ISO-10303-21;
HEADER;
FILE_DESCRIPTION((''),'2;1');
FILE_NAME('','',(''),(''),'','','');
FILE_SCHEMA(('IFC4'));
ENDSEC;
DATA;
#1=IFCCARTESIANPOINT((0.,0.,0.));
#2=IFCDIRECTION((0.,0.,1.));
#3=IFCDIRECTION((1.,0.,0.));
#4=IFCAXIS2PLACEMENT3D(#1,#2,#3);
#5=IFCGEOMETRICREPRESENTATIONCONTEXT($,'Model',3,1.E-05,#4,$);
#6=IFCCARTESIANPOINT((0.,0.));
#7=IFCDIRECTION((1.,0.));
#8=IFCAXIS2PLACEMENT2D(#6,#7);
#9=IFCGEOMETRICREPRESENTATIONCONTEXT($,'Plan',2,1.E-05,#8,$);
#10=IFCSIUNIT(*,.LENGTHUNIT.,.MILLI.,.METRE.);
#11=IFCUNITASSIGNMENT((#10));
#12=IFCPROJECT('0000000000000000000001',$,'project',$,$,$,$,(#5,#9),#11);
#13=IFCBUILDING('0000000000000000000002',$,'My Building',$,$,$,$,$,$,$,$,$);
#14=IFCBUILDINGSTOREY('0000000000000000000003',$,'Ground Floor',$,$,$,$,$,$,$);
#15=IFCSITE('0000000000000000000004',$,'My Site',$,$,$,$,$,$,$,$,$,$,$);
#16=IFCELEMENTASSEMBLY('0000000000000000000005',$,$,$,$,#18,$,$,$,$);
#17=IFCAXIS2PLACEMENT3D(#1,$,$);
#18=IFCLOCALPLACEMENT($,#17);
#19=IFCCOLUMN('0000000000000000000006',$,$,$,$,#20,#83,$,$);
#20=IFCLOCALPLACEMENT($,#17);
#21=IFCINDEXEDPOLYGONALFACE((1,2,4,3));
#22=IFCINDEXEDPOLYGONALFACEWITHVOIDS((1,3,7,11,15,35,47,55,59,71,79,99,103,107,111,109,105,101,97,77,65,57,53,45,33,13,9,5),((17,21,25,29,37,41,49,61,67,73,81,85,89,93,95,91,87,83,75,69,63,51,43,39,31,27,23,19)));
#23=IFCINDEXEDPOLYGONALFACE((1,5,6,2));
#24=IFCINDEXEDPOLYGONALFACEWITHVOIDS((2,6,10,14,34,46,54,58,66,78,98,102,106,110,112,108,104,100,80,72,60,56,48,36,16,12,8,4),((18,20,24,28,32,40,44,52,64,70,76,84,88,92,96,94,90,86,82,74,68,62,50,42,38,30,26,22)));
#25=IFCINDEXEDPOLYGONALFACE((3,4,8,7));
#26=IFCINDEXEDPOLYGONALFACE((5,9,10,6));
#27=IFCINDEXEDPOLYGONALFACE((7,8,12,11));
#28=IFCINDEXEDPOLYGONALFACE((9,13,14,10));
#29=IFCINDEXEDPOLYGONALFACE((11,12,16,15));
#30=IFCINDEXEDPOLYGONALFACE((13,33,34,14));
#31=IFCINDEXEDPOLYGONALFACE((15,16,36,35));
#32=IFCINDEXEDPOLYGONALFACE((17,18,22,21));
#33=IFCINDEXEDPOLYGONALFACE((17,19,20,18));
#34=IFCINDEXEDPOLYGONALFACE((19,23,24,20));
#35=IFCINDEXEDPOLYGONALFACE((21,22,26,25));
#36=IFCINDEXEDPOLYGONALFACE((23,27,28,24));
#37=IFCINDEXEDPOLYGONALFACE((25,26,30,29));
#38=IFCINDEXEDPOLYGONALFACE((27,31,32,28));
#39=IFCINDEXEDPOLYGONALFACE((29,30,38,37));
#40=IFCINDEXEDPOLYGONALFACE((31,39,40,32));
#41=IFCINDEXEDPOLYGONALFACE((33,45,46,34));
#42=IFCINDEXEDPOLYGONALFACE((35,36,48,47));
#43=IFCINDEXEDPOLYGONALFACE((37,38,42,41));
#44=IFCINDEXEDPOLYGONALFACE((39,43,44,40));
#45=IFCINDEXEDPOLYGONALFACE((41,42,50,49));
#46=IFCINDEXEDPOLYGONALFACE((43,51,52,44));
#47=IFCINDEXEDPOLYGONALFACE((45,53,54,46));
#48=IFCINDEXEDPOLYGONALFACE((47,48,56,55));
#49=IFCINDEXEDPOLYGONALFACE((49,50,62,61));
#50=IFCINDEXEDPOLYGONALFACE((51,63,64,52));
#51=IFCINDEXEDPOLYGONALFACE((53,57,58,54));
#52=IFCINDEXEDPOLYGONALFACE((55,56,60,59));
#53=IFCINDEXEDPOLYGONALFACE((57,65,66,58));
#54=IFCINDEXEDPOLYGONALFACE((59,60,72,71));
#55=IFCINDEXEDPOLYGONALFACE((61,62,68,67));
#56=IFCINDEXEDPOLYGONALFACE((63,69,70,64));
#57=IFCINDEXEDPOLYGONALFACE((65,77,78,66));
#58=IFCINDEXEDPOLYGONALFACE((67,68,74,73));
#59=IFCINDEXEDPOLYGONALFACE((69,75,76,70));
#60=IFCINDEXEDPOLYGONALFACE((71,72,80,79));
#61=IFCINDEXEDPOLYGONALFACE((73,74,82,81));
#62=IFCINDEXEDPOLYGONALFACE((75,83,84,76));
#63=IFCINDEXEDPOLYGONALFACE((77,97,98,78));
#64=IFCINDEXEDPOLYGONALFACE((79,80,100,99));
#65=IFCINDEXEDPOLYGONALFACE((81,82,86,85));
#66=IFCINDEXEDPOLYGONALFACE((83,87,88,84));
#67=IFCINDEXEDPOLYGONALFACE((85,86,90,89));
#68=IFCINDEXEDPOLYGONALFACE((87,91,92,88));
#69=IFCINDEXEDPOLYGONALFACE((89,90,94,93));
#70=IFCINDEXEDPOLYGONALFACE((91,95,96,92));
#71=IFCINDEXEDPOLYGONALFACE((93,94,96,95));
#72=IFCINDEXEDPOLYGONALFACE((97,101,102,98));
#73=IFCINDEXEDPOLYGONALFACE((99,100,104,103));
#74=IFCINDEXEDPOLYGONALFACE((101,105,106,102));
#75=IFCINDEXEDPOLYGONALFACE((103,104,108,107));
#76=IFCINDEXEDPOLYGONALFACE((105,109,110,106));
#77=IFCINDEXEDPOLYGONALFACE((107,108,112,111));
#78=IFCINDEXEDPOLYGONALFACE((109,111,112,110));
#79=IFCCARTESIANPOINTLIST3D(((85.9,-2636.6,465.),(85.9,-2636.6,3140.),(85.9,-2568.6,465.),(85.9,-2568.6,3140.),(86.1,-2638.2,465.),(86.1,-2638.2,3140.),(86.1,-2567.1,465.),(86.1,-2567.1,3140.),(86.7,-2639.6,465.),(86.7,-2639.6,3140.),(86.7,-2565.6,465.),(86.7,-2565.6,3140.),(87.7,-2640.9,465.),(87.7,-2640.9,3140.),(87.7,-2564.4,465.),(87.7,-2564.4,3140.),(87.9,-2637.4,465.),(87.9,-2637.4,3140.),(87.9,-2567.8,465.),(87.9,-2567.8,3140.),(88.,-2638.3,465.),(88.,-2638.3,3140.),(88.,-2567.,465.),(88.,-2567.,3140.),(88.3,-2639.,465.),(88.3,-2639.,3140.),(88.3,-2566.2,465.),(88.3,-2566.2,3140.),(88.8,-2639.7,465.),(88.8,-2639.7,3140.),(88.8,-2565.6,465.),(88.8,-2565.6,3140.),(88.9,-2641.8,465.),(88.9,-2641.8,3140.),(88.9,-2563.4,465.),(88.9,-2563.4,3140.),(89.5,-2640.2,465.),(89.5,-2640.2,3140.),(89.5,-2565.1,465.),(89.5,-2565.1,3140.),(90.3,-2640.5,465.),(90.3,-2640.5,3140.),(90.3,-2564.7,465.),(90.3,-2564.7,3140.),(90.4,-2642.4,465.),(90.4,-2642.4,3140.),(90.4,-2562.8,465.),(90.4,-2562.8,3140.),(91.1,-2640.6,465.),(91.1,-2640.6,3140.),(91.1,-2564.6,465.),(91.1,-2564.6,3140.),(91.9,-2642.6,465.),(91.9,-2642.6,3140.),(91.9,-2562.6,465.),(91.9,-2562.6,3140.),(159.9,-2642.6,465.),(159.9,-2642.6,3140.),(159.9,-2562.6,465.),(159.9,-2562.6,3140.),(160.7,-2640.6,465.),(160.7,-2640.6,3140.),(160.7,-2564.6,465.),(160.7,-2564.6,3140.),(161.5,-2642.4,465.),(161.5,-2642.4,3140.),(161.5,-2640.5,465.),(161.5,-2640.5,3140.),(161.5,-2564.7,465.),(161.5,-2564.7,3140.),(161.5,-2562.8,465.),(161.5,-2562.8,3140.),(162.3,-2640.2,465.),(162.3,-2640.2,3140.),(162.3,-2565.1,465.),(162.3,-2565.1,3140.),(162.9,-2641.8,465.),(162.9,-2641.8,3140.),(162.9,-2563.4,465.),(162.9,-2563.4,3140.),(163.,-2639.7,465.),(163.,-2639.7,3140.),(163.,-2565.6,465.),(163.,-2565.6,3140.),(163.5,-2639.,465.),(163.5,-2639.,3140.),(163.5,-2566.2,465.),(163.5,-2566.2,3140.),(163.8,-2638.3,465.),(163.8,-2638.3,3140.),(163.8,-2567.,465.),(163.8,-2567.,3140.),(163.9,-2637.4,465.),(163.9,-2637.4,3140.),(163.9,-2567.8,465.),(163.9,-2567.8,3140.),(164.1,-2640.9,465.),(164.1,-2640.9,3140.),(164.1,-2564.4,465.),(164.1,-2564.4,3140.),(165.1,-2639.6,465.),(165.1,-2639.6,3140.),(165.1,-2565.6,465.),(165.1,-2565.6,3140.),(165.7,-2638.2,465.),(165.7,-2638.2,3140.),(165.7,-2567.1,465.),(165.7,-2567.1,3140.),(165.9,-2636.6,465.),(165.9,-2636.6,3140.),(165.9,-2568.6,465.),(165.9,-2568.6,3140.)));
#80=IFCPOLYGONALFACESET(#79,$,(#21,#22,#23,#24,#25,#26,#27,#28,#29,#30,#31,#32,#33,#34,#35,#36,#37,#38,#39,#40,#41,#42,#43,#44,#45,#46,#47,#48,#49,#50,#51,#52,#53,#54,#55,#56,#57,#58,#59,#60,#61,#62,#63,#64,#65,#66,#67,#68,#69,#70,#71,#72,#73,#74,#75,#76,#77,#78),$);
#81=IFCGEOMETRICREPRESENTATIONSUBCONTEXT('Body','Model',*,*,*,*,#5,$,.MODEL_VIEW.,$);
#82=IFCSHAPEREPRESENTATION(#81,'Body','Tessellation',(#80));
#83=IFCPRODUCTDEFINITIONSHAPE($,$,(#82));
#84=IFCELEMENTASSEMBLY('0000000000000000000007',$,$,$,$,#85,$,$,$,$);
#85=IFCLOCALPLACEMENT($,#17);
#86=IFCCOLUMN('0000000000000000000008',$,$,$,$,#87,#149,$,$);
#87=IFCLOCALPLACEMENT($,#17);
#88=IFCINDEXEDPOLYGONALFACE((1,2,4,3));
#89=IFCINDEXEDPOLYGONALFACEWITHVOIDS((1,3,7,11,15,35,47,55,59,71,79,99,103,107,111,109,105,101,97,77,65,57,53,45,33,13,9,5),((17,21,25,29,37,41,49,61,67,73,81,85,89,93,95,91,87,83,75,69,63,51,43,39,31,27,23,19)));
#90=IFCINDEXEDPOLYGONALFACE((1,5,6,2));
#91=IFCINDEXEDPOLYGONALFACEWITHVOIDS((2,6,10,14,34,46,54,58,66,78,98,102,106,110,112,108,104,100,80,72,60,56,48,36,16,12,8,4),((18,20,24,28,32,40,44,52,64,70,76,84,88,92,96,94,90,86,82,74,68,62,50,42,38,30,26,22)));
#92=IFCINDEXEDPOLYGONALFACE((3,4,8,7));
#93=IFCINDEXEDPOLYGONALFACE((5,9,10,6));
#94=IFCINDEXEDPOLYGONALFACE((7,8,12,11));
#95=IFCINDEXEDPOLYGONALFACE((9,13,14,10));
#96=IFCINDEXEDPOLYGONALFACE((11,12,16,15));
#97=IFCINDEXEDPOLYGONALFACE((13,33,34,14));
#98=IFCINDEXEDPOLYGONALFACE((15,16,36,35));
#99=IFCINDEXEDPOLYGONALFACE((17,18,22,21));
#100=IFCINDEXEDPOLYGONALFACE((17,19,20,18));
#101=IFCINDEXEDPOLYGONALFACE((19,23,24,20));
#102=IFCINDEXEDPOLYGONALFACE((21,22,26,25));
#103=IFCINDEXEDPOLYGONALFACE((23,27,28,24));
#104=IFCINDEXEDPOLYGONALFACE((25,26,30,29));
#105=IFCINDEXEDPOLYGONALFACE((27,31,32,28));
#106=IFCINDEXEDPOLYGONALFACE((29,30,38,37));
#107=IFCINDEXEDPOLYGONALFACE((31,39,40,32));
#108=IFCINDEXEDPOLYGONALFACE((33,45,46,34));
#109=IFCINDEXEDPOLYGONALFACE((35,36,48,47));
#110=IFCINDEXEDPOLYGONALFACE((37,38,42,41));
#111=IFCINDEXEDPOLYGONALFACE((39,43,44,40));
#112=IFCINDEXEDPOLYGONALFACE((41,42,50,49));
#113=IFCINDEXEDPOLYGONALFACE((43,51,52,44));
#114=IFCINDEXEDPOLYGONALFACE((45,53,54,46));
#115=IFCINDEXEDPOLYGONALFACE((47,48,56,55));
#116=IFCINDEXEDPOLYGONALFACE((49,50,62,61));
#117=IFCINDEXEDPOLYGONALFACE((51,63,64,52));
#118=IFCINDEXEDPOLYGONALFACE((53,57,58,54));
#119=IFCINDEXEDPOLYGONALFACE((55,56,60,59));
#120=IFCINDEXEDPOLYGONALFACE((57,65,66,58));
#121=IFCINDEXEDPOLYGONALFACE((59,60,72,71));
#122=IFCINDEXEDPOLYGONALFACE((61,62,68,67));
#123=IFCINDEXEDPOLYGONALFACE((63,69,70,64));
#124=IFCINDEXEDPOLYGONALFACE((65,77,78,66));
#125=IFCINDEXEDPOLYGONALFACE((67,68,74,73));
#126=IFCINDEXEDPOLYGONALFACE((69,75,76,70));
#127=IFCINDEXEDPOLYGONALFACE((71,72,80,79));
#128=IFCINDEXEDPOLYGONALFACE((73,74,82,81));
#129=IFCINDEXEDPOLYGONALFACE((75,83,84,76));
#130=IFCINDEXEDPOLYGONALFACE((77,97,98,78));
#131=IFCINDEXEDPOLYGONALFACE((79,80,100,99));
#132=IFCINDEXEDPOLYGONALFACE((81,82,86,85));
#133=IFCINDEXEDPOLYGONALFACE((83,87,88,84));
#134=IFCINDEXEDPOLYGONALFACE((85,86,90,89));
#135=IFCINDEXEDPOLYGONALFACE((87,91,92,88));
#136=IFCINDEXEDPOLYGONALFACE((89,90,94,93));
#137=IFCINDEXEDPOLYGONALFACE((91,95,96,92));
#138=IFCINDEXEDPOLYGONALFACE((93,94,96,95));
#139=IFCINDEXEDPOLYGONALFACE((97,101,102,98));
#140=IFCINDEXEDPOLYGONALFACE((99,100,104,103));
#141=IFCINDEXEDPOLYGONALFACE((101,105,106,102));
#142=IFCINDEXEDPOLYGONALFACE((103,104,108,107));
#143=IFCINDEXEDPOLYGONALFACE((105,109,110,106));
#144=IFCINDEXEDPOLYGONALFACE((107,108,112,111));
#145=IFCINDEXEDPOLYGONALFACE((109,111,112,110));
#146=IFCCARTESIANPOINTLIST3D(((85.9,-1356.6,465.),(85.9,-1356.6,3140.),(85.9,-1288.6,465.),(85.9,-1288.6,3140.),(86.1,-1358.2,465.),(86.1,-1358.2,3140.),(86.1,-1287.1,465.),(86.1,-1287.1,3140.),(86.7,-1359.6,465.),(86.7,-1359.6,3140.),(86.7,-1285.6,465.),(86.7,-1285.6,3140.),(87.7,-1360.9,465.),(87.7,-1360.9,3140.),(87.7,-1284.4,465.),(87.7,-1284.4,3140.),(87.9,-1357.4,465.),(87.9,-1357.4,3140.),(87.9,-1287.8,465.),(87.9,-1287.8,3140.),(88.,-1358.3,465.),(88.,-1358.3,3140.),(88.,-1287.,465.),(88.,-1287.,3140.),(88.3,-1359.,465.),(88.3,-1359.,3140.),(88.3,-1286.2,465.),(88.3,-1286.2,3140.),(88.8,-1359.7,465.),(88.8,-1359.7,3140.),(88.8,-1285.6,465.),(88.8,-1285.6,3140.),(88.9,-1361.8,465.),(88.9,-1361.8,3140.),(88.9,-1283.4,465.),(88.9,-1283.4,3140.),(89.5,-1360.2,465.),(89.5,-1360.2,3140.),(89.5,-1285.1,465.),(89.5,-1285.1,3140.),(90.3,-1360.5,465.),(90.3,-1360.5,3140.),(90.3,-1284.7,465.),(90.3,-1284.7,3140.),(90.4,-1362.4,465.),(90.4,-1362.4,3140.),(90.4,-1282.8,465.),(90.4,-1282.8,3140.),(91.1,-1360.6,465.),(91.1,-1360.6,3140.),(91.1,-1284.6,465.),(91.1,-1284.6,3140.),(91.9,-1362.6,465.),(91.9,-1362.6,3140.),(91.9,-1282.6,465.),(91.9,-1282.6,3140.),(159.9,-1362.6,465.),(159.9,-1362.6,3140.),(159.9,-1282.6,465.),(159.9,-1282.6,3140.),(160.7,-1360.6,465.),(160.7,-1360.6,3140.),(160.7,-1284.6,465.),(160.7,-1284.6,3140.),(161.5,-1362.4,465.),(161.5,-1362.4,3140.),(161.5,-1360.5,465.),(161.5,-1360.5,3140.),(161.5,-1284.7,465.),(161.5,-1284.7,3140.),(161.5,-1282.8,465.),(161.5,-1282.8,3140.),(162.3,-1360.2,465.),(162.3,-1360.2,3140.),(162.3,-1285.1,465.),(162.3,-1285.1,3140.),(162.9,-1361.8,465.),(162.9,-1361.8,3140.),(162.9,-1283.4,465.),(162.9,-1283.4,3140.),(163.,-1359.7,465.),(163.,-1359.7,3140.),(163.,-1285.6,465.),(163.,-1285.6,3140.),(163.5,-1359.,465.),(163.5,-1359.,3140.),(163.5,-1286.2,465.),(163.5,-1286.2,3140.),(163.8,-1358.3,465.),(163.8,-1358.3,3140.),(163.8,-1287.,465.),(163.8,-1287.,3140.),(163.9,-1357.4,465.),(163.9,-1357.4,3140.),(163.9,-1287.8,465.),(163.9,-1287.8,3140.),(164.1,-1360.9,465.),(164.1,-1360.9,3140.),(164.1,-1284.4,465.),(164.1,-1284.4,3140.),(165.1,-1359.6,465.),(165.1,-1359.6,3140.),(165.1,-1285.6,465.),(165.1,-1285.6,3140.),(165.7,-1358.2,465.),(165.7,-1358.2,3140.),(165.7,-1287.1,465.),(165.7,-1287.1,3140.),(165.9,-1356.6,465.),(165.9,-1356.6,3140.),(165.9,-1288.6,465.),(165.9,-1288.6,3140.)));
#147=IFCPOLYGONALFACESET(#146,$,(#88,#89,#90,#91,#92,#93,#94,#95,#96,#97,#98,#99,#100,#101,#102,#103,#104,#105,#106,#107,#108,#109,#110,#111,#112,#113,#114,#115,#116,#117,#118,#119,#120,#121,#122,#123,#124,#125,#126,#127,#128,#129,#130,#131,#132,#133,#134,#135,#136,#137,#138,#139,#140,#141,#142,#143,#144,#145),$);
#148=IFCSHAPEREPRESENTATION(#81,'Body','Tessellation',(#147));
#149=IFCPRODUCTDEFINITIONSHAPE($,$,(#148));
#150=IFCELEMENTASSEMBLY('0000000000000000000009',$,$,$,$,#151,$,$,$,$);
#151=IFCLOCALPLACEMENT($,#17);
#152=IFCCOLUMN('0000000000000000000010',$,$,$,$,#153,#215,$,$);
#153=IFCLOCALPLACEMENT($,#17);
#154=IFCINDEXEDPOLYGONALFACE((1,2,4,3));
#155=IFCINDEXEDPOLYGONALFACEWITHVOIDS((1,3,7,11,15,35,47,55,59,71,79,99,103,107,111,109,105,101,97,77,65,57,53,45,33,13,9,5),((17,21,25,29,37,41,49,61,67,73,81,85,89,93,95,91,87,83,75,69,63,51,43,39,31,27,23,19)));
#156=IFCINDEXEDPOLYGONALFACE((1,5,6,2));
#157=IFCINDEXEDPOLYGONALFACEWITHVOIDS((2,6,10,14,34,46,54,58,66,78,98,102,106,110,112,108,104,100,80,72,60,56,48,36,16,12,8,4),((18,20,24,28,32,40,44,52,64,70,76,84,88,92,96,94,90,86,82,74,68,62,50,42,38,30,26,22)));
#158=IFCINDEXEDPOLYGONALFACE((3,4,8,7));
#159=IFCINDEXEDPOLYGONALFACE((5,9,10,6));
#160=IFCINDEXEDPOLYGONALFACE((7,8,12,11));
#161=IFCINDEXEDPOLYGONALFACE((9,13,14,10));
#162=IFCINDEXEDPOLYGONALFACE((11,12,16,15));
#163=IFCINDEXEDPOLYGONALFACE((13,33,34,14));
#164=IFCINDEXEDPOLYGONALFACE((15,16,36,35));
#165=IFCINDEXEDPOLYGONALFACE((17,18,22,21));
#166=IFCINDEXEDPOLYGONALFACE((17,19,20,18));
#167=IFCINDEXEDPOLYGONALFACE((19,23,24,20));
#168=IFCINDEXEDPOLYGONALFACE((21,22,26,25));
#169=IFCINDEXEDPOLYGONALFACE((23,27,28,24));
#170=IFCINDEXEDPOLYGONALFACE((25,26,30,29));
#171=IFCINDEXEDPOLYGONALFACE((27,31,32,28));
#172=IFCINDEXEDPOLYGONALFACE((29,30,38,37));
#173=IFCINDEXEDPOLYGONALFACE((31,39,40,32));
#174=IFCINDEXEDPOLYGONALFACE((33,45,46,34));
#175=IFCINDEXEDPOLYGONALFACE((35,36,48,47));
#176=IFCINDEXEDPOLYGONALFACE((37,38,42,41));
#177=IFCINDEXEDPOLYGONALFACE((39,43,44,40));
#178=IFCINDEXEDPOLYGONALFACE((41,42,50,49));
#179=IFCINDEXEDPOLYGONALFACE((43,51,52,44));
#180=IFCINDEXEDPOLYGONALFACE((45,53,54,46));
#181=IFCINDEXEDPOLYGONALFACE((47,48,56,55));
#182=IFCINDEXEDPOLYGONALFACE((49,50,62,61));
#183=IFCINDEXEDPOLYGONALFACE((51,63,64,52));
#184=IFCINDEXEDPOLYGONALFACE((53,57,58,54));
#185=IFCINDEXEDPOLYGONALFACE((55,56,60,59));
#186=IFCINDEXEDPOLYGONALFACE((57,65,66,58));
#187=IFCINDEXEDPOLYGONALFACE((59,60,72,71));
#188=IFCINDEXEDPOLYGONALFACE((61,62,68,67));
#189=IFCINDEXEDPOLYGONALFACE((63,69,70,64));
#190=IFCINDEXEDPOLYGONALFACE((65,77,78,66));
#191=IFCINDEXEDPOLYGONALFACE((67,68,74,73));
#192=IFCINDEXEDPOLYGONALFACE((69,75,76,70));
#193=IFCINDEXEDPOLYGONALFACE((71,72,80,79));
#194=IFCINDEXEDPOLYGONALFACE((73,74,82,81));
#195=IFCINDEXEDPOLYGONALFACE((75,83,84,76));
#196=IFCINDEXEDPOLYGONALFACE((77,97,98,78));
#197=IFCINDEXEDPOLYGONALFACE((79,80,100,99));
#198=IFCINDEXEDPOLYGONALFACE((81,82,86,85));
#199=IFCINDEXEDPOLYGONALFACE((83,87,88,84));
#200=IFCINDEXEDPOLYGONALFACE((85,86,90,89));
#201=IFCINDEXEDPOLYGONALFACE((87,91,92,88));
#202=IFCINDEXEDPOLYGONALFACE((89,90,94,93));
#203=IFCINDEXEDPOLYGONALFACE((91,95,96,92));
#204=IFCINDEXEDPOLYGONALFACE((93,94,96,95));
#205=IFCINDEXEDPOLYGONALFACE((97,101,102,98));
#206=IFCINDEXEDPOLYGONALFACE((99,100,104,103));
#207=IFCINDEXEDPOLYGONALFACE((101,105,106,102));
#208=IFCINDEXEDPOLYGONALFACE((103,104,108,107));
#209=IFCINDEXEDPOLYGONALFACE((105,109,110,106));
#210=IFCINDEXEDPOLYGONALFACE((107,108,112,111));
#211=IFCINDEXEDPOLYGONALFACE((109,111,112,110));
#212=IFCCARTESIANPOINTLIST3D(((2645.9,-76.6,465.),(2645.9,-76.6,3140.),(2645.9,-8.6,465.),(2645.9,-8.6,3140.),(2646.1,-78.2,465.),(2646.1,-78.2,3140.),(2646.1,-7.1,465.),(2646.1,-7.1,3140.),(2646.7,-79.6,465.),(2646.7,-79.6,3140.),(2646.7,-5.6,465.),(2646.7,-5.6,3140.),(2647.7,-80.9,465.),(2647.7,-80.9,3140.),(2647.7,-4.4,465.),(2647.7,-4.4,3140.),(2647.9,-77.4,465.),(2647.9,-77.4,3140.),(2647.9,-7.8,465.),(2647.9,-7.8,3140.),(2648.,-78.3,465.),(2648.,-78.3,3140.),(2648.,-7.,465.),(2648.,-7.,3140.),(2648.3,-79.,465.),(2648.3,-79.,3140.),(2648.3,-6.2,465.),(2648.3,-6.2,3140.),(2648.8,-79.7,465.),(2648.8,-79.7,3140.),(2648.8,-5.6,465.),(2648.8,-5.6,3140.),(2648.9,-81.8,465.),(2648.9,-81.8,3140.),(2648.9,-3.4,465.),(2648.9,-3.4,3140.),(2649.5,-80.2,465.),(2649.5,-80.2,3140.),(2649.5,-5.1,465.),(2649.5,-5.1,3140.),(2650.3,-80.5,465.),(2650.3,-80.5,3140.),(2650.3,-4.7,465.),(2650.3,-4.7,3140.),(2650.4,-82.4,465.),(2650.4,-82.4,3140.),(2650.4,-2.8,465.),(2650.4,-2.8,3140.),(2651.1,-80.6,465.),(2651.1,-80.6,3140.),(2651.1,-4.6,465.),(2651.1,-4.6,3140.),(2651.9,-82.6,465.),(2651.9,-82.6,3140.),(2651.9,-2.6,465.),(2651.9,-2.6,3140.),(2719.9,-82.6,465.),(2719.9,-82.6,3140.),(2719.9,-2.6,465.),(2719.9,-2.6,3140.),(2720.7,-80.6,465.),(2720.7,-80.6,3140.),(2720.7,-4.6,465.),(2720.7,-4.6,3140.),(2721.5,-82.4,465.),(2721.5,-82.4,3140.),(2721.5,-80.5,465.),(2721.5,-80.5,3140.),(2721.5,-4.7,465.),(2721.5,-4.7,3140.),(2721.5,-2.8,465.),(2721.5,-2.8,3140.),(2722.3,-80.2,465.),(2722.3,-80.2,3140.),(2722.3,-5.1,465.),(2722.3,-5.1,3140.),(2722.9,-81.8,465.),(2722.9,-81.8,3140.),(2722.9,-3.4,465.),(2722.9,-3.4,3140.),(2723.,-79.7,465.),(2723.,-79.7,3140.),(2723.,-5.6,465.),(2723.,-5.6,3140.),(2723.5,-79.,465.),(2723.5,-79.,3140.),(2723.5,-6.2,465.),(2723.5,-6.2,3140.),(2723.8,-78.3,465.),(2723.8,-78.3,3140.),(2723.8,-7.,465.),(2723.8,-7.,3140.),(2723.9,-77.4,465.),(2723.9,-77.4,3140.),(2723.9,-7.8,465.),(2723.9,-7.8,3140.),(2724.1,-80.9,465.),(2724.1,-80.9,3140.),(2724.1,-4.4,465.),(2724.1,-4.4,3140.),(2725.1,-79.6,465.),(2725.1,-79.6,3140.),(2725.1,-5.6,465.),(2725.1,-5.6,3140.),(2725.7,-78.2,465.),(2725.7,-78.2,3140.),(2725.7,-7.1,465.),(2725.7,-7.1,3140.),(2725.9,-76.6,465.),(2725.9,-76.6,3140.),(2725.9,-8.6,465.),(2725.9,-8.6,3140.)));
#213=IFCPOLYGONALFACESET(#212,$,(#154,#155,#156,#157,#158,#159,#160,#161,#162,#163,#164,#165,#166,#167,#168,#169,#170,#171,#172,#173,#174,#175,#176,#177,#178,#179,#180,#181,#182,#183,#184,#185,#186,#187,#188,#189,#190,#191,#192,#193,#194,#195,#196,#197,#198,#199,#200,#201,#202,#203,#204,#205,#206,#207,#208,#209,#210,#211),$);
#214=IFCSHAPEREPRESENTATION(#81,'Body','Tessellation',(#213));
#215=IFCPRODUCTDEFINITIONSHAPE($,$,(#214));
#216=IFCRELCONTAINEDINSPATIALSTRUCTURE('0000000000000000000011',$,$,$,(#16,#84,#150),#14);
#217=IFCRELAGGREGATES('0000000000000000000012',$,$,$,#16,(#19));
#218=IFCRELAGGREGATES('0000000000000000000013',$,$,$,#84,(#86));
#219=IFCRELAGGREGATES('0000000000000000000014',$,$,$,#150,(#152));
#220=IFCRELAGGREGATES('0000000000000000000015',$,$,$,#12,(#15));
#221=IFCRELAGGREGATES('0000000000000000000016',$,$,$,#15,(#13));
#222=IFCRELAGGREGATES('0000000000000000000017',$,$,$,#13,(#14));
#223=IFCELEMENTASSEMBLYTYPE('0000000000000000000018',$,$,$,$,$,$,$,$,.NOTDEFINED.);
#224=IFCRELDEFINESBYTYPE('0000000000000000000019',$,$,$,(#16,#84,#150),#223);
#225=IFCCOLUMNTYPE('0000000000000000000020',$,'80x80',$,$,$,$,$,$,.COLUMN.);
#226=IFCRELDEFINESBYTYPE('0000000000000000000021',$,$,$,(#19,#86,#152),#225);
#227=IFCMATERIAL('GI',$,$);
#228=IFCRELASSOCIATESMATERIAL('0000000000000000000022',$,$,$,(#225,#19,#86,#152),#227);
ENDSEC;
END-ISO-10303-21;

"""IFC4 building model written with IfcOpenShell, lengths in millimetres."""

from ifc_helpers import new_model, si_unit, frame, origin_with_axes, origin_2d_with_axis, place, context, subcontext, project, spatial, hollow_rectangle, extrude, material, material_profile, profile_set, profile_usage, type_object, element, aggregate, save


model = new_model("IFC4")

# Units and contexts
model_context = context("Model", 3, precision=1e-05, world=origin_with_axes())
plan_context = context("Plan", 2, precision=1e-05, world=origin_2d_with_axis())
body_context = subcontext(model_context, "Body", "Model", "MODEL_VIEW")
ifc_project = project(units=[si_unit("LENGTHUNIT", "METRE", prefix="MILLI")], contexts=[model_context, plan_context])

# Site, building, storey
site = spatial("IfcSite", under=ifc_project, Name="My Site")
building = spatial("IfcBuilding", under=site, Name="My Building")
storey = spatial("IfcBuildingStorey", under=building, Name="Ground Floor")

# Element assemblies, columns
element_assembly_type_1 = type_object("IfcElementAssemblyType", PredefinedType="NOTDEFINED")
ifc_material_1 = material(Name="GI")
ifc_material_profile_1 = material_profile(ifc_material_1, hollow_rectangle(XDim=80.0, YDim=80.0, WallThickness=2.0, InnerFilletRadius=3.2, OuterFilletRadius=6.0))
ifc_profile_set_1 = profile_set([ifc_material_profile_1], Name="80x80 GI Rectangular Hollow")
column_type = type_object("IfcColumnType", Name="80x80", PredefinedType="COLUMN", material=ifc_profile_set_1)
assembly_1_placement = place(None, frame((125.9, -2602.6, 465.0), z_axis=(0.0, 0.0, 1.0), x_axis=(1.0, 0.0, 0.0)))
assembly_1 = element("IfcElementAssembly", 1, at=assembly_1_placement, inside=storey, type_object=element_assembly_type_1)
ifc_profile_usage_1 = profile_usage(ifc_profile_set_1)
column_1_placement = place(assembly_1_placement, origin_with_axes())
column_1 = element("IfcColumn", 2, at=column_1_placement, type_object=column_type, material=ifc_profile_usage_1, context=body_context, shape_type="SweptSolid", body=[
    extrude(hollow_rectangle(XDim=80.0, YDim=80.0, WallThickness=2.0, InnerFilletRadius=3.2, OuterFilletRadius=6.0), origin_with_axes(), (0.0, 0.0, 1.0), 2675.0),
])
aggregate(assembly_1, [column_1])
assembly_2_placement = place(None, frame((125.9, -1322.6, 465.0), z_axis=(0.0, 0.0, 1.0), x_axis=(1.0, 0.0, 0.0)))
assembly_2 = element("IfcElementAssembly", 3, at=assembly_2_placement, inside=storey, type_object=element_assembly_type_1)
ifc_profile_usage_2 = profile_usage(ifc_profile_set_1)
column_2_placement = place(assembly_2_placement, origin_with_axes())
column_2 = element("IfcColumn", 4, at=column_2_placement, type_object=column_type, material=ifc_profile_usage_2, context=body_context, shape_type="SweptSolid", body=[
    extrude(hollow_rectangle(XDim=80.0, YDim=80.0, WallThickness=2.0, InnerFilletRadius=3.2, OuterFilletRadius=6.0), origin_with_axes(), (0.0, 0.0, 1.0), 2675.0),
])
aggregate(assembly_2, [column_2])
assembly_3_placement = place(None, frame((2685.9, -42.6, 465.0), z_axis=(0.0, 0.0, 1.0), x_axis=(1.0, 0.0, 0.0)))
assembly_3 = element("IfcElementAssembly", 5, at=assembly_3_placement, inside=storey, type_object=element_assembly_type_1)
ifc_profile_usage_3 = profile_usage(ifc_profile_set_1)
column_3_placement = place(assembly_3_placement, origin_with_axes())
column_3 = element("IfcColumn", 6, at=column_3_placement, type_object=column_type, material=ifc_profile_usage_3, context=body_context, shape_type="SweptSolid", body=[
    extrude(hollow_rectangle(XDim=80.0, YDim=80.0, WallThickness=2.0, InnerFilletRadius=3.2, OuterFilletRadius=6.0), origin_with_axes(), (0.0, 0.0, 1.0), 2675.0),
])
aggregate(assembly_3, [column_3])

save(model, "model.ifc")
